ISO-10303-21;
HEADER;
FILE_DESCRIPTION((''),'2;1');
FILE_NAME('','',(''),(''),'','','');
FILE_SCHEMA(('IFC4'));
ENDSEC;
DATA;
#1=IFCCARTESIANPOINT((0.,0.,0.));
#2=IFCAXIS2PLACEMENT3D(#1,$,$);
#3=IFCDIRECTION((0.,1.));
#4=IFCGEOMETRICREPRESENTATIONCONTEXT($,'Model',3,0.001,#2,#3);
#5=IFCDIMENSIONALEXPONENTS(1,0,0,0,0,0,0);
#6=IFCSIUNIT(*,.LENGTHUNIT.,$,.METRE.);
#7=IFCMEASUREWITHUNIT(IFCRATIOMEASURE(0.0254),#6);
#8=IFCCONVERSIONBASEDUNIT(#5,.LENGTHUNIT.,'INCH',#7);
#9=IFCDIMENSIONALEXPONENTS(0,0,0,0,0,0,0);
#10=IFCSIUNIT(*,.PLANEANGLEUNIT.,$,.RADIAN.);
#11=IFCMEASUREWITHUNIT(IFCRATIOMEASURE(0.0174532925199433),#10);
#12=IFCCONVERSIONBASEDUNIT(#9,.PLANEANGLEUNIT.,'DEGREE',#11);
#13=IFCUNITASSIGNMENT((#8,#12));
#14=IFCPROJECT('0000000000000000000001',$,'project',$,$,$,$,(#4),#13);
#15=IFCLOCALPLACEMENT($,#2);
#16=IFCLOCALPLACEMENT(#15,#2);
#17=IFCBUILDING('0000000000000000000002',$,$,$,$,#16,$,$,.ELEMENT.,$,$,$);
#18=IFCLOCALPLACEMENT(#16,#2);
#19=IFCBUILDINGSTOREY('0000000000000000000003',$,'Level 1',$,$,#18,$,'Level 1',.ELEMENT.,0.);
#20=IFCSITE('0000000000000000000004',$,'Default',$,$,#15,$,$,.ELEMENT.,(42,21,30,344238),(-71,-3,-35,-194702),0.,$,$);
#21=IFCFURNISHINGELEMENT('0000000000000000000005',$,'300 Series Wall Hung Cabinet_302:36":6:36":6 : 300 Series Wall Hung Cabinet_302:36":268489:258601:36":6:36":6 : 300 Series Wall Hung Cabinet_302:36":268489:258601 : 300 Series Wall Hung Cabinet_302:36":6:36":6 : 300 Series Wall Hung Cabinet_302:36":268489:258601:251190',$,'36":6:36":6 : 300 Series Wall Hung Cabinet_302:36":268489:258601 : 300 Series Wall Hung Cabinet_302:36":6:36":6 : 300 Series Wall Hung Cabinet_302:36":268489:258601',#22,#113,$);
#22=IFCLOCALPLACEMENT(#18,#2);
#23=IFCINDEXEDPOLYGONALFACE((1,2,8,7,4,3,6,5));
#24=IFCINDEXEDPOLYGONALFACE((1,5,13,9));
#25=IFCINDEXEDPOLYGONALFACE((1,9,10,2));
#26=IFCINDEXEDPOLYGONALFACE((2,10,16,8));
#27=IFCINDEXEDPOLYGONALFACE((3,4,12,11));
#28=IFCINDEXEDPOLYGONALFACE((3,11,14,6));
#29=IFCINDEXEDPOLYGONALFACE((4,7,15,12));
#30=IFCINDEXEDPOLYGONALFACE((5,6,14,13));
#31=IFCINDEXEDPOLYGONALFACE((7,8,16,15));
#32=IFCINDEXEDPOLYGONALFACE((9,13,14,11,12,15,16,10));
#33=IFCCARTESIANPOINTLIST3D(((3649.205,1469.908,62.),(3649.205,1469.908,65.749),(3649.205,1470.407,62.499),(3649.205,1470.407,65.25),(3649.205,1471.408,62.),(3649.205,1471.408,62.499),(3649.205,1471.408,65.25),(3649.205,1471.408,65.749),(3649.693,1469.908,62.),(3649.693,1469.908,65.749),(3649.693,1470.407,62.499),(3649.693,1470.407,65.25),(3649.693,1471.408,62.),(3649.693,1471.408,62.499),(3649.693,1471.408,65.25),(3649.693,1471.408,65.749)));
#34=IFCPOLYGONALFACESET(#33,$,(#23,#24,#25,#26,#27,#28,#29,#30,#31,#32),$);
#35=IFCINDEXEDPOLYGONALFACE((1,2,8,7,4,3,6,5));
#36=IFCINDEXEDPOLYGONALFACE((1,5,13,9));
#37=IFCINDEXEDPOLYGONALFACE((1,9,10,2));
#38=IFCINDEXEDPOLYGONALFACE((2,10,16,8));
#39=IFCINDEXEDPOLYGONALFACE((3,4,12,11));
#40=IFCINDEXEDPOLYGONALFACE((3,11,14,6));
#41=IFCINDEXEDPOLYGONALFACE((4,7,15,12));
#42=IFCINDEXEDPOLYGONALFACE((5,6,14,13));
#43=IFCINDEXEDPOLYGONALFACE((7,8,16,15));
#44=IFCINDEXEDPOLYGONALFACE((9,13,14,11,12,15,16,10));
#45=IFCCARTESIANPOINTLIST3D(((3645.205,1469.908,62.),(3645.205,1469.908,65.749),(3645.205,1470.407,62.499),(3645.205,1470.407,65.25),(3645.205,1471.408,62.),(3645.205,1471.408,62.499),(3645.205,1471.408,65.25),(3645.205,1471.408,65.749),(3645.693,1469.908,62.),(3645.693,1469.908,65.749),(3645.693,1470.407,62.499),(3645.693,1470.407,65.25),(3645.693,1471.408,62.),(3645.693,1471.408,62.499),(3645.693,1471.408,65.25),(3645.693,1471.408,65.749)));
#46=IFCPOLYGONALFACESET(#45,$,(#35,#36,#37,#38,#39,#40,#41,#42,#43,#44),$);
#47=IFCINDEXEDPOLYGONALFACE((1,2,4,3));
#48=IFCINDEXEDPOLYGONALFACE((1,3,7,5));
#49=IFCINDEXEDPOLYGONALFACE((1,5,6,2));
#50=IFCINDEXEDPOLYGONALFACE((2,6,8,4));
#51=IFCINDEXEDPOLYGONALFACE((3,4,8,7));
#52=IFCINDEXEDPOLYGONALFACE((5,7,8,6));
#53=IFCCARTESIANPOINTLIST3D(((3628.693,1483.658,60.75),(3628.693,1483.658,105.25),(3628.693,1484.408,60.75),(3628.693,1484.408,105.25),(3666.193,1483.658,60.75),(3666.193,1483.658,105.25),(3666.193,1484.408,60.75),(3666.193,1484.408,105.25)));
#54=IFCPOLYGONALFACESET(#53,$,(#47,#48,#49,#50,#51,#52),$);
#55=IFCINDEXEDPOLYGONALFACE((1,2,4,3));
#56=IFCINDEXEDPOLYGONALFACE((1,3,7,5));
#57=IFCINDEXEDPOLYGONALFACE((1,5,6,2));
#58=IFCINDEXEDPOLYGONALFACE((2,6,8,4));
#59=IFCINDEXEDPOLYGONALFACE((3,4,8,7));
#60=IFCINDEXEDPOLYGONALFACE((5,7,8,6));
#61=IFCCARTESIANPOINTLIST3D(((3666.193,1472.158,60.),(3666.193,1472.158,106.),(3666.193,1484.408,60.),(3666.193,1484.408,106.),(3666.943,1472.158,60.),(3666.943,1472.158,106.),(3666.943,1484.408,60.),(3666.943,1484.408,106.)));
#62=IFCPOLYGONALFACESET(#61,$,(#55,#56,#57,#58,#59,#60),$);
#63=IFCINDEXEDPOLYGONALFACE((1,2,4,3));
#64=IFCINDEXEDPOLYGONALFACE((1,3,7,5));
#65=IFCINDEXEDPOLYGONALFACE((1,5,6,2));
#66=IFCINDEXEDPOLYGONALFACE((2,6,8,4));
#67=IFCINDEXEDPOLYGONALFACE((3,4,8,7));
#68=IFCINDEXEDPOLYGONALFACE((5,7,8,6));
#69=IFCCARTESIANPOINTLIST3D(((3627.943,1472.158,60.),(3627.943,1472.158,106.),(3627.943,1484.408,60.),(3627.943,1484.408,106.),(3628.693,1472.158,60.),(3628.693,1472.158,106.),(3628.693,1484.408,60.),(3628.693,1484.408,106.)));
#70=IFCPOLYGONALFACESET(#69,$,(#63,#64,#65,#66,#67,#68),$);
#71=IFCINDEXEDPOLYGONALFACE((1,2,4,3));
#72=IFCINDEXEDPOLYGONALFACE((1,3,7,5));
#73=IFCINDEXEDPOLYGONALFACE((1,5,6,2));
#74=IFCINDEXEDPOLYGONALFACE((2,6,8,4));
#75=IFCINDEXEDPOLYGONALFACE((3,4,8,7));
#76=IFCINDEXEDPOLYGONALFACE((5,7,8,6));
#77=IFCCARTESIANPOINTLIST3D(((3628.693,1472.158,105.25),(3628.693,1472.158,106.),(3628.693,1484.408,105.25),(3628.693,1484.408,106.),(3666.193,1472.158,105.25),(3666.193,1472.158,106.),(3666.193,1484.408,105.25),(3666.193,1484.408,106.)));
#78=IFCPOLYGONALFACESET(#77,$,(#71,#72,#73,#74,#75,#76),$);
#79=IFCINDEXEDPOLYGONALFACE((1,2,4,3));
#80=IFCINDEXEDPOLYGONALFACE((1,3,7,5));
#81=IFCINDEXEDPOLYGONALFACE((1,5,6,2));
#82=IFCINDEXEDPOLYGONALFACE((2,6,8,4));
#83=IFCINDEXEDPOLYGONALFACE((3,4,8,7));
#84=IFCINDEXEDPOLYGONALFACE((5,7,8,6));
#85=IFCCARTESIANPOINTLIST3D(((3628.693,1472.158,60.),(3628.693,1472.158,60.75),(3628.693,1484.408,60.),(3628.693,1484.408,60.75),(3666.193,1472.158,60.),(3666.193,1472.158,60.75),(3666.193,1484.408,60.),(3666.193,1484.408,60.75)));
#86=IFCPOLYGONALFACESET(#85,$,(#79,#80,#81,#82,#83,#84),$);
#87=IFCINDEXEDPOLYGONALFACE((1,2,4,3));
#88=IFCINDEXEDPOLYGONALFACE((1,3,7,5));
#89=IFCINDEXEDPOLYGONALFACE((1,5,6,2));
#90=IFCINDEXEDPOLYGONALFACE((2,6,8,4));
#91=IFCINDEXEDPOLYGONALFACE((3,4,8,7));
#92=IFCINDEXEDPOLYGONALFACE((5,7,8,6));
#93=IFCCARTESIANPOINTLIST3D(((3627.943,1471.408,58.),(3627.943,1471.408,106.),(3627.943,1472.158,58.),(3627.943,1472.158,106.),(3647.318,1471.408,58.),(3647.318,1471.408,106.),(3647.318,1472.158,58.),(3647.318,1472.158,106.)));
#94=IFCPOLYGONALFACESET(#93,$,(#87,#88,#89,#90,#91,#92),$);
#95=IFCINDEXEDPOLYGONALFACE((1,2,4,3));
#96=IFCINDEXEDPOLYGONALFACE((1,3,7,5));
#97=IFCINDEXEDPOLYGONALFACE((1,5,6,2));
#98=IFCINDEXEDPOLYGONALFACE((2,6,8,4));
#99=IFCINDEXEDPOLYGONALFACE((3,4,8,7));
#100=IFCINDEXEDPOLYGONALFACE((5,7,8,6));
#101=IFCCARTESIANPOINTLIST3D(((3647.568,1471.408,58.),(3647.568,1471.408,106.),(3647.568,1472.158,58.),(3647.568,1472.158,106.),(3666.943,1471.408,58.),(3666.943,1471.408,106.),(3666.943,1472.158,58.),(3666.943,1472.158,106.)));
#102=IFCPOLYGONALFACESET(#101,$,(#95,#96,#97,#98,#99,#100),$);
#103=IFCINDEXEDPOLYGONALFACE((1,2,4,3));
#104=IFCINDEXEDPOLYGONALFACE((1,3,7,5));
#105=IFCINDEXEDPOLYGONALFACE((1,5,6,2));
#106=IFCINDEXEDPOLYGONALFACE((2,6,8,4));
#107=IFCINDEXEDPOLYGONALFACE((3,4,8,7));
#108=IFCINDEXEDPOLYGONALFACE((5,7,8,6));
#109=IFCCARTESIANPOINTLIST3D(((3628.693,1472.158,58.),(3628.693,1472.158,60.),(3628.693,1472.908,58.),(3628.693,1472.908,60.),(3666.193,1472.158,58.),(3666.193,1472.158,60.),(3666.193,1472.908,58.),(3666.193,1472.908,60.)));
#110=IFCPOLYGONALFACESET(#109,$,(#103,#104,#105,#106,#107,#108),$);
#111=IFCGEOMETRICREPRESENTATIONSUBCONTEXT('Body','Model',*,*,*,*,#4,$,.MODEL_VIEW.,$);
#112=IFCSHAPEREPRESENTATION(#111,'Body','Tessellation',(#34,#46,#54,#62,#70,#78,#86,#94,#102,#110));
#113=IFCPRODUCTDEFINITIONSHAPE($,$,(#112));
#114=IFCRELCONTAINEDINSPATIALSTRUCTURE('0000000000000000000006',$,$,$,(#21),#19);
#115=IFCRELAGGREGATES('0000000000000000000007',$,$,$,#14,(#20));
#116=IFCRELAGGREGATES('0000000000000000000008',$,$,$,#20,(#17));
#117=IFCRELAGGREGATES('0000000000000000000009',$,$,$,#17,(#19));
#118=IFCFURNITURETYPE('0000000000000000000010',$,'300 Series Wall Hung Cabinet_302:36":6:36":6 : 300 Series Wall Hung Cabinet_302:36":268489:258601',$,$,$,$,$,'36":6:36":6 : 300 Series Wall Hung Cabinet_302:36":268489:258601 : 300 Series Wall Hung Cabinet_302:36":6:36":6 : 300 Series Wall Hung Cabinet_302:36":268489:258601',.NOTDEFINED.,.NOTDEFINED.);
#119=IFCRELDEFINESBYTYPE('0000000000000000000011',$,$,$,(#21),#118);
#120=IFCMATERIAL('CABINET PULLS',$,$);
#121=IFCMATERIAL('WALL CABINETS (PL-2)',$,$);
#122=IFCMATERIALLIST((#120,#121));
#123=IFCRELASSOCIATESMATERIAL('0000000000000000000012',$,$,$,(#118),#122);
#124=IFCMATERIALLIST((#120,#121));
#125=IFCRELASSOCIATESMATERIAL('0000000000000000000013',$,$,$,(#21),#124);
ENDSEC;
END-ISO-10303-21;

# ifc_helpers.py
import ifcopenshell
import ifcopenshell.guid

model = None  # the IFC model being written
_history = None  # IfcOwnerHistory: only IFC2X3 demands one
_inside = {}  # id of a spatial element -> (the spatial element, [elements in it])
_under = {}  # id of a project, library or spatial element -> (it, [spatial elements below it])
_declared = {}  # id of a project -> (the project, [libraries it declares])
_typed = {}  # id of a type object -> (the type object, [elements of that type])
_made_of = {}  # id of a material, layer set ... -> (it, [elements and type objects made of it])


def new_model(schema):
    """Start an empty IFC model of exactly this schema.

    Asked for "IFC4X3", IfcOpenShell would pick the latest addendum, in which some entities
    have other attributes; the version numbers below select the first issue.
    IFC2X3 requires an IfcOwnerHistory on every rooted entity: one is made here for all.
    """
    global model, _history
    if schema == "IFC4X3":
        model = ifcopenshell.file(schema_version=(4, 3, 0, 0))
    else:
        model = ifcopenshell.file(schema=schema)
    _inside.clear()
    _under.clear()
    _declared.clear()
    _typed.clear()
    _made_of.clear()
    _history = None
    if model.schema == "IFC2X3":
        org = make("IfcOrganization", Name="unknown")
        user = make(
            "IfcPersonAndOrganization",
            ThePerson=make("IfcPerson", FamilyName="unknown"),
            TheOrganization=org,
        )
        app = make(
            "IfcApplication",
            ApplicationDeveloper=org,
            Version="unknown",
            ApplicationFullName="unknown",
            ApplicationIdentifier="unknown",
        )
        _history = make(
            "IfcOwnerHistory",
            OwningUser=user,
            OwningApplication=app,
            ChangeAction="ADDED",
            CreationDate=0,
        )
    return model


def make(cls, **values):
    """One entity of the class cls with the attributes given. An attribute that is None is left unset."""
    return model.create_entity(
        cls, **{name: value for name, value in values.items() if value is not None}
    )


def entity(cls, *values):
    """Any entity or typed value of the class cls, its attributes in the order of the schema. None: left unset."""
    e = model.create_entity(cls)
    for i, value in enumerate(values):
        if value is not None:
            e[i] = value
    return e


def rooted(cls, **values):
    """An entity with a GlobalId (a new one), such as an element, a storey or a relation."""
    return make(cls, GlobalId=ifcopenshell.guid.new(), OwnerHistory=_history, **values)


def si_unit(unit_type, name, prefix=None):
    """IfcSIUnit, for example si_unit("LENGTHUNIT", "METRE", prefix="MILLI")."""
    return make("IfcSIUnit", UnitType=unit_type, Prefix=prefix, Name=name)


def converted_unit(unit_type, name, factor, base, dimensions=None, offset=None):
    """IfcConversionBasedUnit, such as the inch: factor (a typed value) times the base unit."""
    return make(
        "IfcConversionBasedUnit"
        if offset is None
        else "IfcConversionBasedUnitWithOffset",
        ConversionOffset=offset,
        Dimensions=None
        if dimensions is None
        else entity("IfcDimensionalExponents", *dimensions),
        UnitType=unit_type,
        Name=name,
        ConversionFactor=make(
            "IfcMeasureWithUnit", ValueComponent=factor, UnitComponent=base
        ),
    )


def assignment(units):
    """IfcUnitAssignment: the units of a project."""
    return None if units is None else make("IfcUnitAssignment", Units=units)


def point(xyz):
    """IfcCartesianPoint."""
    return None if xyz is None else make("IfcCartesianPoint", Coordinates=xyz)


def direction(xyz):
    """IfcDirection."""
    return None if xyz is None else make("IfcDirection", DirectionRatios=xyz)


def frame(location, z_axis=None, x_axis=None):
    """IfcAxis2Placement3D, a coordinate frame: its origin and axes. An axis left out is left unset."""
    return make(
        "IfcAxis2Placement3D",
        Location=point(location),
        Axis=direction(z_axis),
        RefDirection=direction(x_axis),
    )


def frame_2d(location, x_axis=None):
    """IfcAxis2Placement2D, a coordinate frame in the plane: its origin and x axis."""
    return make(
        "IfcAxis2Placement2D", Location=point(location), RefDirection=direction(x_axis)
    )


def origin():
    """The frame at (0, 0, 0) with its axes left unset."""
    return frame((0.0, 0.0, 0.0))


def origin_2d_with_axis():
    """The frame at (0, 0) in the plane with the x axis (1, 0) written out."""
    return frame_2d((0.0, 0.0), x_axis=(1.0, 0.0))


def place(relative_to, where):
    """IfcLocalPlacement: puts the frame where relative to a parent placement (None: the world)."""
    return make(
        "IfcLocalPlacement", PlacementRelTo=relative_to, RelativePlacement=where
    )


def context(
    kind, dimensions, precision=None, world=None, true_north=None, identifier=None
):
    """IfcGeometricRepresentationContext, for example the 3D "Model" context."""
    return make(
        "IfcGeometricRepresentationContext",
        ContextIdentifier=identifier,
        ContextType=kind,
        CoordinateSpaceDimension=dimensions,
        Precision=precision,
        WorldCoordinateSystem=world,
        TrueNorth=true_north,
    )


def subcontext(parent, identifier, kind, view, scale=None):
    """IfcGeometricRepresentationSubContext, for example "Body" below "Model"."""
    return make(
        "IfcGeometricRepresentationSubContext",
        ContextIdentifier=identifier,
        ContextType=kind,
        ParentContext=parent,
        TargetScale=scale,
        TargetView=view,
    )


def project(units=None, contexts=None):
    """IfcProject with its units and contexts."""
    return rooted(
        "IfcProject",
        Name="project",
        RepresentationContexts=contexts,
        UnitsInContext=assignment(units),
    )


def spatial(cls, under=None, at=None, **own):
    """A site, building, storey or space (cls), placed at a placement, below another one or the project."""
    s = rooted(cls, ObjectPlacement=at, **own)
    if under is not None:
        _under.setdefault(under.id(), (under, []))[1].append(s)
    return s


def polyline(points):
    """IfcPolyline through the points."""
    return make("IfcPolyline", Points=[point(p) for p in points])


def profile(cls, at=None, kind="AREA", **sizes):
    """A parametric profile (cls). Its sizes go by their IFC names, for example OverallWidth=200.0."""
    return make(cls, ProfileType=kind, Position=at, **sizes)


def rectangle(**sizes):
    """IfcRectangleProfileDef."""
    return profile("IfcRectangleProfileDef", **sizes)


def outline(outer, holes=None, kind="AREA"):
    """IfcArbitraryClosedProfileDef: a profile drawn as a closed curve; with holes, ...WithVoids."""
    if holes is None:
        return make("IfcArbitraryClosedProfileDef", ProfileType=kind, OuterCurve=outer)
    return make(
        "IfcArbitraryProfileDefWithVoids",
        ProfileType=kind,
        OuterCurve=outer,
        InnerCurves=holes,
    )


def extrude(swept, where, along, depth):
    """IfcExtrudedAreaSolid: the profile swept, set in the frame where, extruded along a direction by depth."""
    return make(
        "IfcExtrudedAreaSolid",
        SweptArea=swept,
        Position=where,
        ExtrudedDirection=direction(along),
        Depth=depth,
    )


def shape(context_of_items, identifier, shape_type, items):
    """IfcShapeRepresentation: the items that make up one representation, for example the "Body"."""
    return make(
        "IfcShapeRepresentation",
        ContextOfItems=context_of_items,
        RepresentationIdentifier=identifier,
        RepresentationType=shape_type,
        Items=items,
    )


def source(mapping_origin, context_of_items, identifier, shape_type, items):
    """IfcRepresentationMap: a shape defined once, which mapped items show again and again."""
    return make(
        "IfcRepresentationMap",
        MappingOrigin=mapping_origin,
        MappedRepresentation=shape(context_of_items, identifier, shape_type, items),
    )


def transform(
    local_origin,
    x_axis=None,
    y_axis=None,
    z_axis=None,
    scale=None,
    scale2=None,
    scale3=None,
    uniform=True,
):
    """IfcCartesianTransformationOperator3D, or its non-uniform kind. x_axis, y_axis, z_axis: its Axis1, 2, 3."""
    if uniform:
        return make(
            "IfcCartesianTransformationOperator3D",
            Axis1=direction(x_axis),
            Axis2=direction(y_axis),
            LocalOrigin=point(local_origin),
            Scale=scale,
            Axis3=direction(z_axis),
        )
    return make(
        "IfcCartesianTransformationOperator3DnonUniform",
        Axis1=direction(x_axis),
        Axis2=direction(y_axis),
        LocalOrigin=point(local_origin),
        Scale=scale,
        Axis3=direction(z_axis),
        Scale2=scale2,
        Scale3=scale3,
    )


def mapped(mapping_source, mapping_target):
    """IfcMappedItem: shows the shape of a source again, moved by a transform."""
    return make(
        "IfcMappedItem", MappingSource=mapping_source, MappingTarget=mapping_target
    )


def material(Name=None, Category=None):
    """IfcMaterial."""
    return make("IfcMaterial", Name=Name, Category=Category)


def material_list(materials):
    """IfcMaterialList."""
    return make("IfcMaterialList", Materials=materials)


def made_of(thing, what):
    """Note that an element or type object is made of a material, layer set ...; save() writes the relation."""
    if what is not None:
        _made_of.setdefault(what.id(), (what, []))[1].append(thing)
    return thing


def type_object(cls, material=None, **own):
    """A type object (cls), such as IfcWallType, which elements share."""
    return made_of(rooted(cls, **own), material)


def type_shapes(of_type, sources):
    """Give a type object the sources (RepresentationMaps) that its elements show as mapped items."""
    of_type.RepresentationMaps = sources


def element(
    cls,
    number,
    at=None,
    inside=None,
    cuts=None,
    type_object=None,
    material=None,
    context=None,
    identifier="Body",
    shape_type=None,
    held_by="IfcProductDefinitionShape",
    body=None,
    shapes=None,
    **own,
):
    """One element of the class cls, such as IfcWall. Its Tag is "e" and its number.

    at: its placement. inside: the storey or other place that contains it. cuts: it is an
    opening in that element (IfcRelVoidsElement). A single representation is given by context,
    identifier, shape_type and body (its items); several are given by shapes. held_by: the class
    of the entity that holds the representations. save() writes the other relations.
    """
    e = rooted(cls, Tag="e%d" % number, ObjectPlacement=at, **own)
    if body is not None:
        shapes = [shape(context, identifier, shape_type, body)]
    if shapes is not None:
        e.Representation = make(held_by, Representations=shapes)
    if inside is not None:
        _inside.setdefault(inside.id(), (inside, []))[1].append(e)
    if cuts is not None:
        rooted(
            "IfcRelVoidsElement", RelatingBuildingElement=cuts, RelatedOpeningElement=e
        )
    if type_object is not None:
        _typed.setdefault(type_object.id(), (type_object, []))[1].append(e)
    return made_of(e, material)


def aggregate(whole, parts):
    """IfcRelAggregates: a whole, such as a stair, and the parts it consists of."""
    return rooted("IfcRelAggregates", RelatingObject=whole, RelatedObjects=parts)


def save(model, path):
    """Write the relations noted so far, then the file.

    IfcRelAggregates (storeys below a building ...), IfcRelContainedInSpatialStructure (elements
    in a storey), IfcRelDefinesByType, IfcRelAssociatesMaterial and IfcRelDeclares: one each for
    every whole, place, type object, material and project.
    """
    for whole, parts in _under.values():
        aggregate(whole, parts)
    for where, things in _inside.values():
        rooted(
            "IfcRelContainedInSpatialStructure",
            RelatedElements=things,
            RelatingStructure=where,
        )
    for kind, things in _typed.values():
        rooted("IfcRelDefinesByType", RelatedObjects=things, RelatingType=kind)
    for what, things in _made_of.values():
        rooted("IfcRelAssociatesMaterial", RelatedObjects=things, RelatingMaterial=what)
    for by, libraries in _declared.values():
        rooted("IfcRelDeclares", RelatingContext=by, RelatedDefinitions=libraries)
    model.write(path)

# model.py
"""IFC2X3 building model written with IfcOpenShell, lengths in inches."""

from ifc_helpers import new_model, entity, si_unit, converted_unit, direction, frame, frame_2d, origin, origin_2d_with_axis, place, context, subcontext, project, spatial, polyline, rectangle, outline, extrude, source, transform, mapped, material, material_list, type_object, type_shapes, element, save


model = new_model("IFC2X3")

# Units and contexts
model_context = context("Model", 3, precision=0.001, world=origin(), true_north=direction((0.0, 1.0)))
body_context = subcontext(model_context, "Body", "Model", "MODEL_VIEW")
ifc_project = project(units=[converted_unit("LENGTHUNIT", "INCH", entity("IfcRatioMeasure", 0.0254), si_unit("LENGTHUNIT", "METRE"), dimensions=[1, 0, 0, 0, 0, 0, 0]), converted_unit("PLANEANGLEUNIT", "DEGREE", entity("IfcRatioMeasure", 0.0174532925199433), si_unit("PLANEANGLEUNIT", "RADIAN"), dimensions=[0, 0, 0, 0, 0, 0, 0])], contexts=[model_context])

# Site, building, storey
site_placement = place(None, origin())
site = spatial("IfcSite", under=ifc_project, at=site_placement, Name="Default", CompositionType="ELEMENT", RefLatitude=(42, 21, 30, 344238), RefLongitude=(-71, -3, -35, -194702), RefElevation=0.0)
building_placement = place(site_placement, origin())
building = spatial("IfcBuilding", under=site, at=building_placement, CompositionType="ELEMENT")
storey_placement = place(building_placement, origin())
storey = spatial("IfcBuildingStorey", under=building, at=storey_placement, Name="Level 1", LongName="Level 1", CompositionType="ELEMENT", Elevation=0.0)

# Furnishing element
ifc_material_1 = material(Name="CABINET PULLS")
ifc_material_2 = material(Name="WALL CABINETS (PL-2)")
ifc_material_list_1 = material_list([ifc_material_1, ifc_material_2])
ifc_material_list_2 = material_list([ifc_material_1, ifc_material_2])
furniture_type_1 = type_object("IfcFurnitureType", Name="300 Series Wall Hung Cabinet_302:36\":6:36\":6 : 300 Series Wall Hung Cabinet_302:36\":268489:258601", ElementType="36\":6:36\":6 : 300 Series Wall Hung Cabinet_302:36\":268489:258601 : 300 Series Wall Hung Cabinet_302:36\":6:36\":6 : 300 Series Wall Hung Cabinet_302:36\":268489:258601", AssemblyPlace="NOTDEFINED", material=ifc_material_list_2)
shared_shape_1 = source(origin(), body_context, "Body", "SweptSolid", [
    extrude(outline(polyline([(1.375, -0.625), (1.874, -0.625), (1.874, 0.874), (-1.874, 0.874), (-1.874, -0.625), (-1.375, -0.625), (-1.375, 0.376), (1.375, 0.376), (1.375, -0.625)])), frame((3649.205, 1470.783, 63.874), z_axis=(1.0, 0.0, 0.0), x_axis=(0.0, 0.0, 1.0)), (0.0, 0.0, 1.0), 0.488),
    extrude(outline(polyline([(1.375, -0.625), (1.874, -0.625), (1.874, 0.874), (-1.874, 0.874), (-1.874, -0.625), (-1.375, -0.625), (-1.375, 0.376), (1.375, 0.376), (1.375, -0.625)])), frame((3645.205, 1470.783, 63.874), z_axis=(1.0, 0.0, 0.0), x_axis=(0.0, 0.0, 1.0)), (0.0, 0.0, 1.0), 0.488),
    extrude(rectangle(XDim=0.75, YDim=37.5, at=origin_2d_with_axis()), frame((3647.443, 1484.033, 60.75), z_axis=(0.0, 0.0, 1.0), x_axis=(0.0, 1.0, 0.0)), (0.0, 0.0, 1.0), 44.5),
    extrude(rectangle(XDim=0.75, YDim=12.25, at=origin_2d_with_axis()), frame((3666.568, 1478.283, 60.0)), (0.0, 0.0, 1.0), 46.0),
    extrude(rectangle(XDim=0.75, YDim=12.25, at=origin_2d_with_axis()), frame((3628.318, 1478.283, 60.0)), (0.0, 0.0, 1.0), 46.0),
    extrude(rectangle(XDim=37.5, YDim=12.25, at=frame_2d((0.0, 0.0), x_axis=(1.0, 0.0))), frame((3647.443, 1478.283, 105.25), z_axis=(0.0, 0.0, 1.0), x_axis=(-1.0, 0.0, 0.0)), (0.0, 0.0, 1.0), 0.75),
    extrude(rectangle(XDim=37.5, YDim=12.25, at=frame_2d((0.0, 0.0), x_axis=(1.0, 0.0))), frame((3647.443, 1478.283, 60.0), z_axis=(0.0, 0.0, 1.0), x_axis=(-1.0, 0.0, 0.0)), (0.0, 0.0, 1.0), 0.75),
    extrude(rectangle(XDim=19.375, YDim=0.75, at=frame_2d((0.0, 0.0), x_axis=(1.0, 0.0))), frame((3637.631, 1471.783, 58.0), z_axis=(0.0, 0.0, 1.0), x_axis=(-1.0, 0.0, 0.0)), (0.0, 0.0, 1.0), 48.0),
    extrude(rectangle(XDim=19.375, YDim=0.75, at=frame_2d((0.0, 0.0), x_axis=(1.0, 0.0))), frame((3657.256, 1471.783, 58.0), z_axis=(0.0, 0.0, 1.0), x_axis=(-1.0, 0.0, 0.0)), (0.0, 0.0, 1.0), 48.0),
    extrude(rectangle(XDim=0.75, YDim=37.5, at=origin_2d_with_axis()), frame((3647.443, 1472.533, 58.0), z_axis=(0.0, 0.0, 1.0), x_axis=(0.0, 1.0, 0.0)), (0.0, 0.0, 1.0), 2.0),
])
type_shapes(furniture_type_1, [shared_shape_1])
furnishing_1_placement = place(storey_placement, origin())
element("IfcFurnishingElement", 1, at=furnishing_1_placement, inside=storey, type_object=furniture_type_1, material=ifc_material_list_1, Name="300 Series Wall Hung Cabinet_302:36\":6:36\":6 : 300 Series Wall Hung Cabinet_302:36\":268489:258601:36\":6:36\":6 : 300 Series Wall Hung Cabinet_302:36\":268489:258601 : 300 Series Wall Hung Cabinet_302:36\":6:36\":6 : 300 Series Wall Hung Cabinet_302:36\":268489:258601:251190", ObjectType="36\":6:36\":6 : 300 Series Wall Hung Cabinet_302:36\":268489:258601 : 300 Series Wall Hung Cabinet_302:36\":6:36\":6 : 300 Series Wall Hung Cabinet_302:36\":268489:258601", context=body_context, shape_type="MappedRepresentation", body=[
    mapped(shared_shape_1, transform((0.0, 0.0, 0.0), scale=1.0)),
])

save(model, "model.ifc")
